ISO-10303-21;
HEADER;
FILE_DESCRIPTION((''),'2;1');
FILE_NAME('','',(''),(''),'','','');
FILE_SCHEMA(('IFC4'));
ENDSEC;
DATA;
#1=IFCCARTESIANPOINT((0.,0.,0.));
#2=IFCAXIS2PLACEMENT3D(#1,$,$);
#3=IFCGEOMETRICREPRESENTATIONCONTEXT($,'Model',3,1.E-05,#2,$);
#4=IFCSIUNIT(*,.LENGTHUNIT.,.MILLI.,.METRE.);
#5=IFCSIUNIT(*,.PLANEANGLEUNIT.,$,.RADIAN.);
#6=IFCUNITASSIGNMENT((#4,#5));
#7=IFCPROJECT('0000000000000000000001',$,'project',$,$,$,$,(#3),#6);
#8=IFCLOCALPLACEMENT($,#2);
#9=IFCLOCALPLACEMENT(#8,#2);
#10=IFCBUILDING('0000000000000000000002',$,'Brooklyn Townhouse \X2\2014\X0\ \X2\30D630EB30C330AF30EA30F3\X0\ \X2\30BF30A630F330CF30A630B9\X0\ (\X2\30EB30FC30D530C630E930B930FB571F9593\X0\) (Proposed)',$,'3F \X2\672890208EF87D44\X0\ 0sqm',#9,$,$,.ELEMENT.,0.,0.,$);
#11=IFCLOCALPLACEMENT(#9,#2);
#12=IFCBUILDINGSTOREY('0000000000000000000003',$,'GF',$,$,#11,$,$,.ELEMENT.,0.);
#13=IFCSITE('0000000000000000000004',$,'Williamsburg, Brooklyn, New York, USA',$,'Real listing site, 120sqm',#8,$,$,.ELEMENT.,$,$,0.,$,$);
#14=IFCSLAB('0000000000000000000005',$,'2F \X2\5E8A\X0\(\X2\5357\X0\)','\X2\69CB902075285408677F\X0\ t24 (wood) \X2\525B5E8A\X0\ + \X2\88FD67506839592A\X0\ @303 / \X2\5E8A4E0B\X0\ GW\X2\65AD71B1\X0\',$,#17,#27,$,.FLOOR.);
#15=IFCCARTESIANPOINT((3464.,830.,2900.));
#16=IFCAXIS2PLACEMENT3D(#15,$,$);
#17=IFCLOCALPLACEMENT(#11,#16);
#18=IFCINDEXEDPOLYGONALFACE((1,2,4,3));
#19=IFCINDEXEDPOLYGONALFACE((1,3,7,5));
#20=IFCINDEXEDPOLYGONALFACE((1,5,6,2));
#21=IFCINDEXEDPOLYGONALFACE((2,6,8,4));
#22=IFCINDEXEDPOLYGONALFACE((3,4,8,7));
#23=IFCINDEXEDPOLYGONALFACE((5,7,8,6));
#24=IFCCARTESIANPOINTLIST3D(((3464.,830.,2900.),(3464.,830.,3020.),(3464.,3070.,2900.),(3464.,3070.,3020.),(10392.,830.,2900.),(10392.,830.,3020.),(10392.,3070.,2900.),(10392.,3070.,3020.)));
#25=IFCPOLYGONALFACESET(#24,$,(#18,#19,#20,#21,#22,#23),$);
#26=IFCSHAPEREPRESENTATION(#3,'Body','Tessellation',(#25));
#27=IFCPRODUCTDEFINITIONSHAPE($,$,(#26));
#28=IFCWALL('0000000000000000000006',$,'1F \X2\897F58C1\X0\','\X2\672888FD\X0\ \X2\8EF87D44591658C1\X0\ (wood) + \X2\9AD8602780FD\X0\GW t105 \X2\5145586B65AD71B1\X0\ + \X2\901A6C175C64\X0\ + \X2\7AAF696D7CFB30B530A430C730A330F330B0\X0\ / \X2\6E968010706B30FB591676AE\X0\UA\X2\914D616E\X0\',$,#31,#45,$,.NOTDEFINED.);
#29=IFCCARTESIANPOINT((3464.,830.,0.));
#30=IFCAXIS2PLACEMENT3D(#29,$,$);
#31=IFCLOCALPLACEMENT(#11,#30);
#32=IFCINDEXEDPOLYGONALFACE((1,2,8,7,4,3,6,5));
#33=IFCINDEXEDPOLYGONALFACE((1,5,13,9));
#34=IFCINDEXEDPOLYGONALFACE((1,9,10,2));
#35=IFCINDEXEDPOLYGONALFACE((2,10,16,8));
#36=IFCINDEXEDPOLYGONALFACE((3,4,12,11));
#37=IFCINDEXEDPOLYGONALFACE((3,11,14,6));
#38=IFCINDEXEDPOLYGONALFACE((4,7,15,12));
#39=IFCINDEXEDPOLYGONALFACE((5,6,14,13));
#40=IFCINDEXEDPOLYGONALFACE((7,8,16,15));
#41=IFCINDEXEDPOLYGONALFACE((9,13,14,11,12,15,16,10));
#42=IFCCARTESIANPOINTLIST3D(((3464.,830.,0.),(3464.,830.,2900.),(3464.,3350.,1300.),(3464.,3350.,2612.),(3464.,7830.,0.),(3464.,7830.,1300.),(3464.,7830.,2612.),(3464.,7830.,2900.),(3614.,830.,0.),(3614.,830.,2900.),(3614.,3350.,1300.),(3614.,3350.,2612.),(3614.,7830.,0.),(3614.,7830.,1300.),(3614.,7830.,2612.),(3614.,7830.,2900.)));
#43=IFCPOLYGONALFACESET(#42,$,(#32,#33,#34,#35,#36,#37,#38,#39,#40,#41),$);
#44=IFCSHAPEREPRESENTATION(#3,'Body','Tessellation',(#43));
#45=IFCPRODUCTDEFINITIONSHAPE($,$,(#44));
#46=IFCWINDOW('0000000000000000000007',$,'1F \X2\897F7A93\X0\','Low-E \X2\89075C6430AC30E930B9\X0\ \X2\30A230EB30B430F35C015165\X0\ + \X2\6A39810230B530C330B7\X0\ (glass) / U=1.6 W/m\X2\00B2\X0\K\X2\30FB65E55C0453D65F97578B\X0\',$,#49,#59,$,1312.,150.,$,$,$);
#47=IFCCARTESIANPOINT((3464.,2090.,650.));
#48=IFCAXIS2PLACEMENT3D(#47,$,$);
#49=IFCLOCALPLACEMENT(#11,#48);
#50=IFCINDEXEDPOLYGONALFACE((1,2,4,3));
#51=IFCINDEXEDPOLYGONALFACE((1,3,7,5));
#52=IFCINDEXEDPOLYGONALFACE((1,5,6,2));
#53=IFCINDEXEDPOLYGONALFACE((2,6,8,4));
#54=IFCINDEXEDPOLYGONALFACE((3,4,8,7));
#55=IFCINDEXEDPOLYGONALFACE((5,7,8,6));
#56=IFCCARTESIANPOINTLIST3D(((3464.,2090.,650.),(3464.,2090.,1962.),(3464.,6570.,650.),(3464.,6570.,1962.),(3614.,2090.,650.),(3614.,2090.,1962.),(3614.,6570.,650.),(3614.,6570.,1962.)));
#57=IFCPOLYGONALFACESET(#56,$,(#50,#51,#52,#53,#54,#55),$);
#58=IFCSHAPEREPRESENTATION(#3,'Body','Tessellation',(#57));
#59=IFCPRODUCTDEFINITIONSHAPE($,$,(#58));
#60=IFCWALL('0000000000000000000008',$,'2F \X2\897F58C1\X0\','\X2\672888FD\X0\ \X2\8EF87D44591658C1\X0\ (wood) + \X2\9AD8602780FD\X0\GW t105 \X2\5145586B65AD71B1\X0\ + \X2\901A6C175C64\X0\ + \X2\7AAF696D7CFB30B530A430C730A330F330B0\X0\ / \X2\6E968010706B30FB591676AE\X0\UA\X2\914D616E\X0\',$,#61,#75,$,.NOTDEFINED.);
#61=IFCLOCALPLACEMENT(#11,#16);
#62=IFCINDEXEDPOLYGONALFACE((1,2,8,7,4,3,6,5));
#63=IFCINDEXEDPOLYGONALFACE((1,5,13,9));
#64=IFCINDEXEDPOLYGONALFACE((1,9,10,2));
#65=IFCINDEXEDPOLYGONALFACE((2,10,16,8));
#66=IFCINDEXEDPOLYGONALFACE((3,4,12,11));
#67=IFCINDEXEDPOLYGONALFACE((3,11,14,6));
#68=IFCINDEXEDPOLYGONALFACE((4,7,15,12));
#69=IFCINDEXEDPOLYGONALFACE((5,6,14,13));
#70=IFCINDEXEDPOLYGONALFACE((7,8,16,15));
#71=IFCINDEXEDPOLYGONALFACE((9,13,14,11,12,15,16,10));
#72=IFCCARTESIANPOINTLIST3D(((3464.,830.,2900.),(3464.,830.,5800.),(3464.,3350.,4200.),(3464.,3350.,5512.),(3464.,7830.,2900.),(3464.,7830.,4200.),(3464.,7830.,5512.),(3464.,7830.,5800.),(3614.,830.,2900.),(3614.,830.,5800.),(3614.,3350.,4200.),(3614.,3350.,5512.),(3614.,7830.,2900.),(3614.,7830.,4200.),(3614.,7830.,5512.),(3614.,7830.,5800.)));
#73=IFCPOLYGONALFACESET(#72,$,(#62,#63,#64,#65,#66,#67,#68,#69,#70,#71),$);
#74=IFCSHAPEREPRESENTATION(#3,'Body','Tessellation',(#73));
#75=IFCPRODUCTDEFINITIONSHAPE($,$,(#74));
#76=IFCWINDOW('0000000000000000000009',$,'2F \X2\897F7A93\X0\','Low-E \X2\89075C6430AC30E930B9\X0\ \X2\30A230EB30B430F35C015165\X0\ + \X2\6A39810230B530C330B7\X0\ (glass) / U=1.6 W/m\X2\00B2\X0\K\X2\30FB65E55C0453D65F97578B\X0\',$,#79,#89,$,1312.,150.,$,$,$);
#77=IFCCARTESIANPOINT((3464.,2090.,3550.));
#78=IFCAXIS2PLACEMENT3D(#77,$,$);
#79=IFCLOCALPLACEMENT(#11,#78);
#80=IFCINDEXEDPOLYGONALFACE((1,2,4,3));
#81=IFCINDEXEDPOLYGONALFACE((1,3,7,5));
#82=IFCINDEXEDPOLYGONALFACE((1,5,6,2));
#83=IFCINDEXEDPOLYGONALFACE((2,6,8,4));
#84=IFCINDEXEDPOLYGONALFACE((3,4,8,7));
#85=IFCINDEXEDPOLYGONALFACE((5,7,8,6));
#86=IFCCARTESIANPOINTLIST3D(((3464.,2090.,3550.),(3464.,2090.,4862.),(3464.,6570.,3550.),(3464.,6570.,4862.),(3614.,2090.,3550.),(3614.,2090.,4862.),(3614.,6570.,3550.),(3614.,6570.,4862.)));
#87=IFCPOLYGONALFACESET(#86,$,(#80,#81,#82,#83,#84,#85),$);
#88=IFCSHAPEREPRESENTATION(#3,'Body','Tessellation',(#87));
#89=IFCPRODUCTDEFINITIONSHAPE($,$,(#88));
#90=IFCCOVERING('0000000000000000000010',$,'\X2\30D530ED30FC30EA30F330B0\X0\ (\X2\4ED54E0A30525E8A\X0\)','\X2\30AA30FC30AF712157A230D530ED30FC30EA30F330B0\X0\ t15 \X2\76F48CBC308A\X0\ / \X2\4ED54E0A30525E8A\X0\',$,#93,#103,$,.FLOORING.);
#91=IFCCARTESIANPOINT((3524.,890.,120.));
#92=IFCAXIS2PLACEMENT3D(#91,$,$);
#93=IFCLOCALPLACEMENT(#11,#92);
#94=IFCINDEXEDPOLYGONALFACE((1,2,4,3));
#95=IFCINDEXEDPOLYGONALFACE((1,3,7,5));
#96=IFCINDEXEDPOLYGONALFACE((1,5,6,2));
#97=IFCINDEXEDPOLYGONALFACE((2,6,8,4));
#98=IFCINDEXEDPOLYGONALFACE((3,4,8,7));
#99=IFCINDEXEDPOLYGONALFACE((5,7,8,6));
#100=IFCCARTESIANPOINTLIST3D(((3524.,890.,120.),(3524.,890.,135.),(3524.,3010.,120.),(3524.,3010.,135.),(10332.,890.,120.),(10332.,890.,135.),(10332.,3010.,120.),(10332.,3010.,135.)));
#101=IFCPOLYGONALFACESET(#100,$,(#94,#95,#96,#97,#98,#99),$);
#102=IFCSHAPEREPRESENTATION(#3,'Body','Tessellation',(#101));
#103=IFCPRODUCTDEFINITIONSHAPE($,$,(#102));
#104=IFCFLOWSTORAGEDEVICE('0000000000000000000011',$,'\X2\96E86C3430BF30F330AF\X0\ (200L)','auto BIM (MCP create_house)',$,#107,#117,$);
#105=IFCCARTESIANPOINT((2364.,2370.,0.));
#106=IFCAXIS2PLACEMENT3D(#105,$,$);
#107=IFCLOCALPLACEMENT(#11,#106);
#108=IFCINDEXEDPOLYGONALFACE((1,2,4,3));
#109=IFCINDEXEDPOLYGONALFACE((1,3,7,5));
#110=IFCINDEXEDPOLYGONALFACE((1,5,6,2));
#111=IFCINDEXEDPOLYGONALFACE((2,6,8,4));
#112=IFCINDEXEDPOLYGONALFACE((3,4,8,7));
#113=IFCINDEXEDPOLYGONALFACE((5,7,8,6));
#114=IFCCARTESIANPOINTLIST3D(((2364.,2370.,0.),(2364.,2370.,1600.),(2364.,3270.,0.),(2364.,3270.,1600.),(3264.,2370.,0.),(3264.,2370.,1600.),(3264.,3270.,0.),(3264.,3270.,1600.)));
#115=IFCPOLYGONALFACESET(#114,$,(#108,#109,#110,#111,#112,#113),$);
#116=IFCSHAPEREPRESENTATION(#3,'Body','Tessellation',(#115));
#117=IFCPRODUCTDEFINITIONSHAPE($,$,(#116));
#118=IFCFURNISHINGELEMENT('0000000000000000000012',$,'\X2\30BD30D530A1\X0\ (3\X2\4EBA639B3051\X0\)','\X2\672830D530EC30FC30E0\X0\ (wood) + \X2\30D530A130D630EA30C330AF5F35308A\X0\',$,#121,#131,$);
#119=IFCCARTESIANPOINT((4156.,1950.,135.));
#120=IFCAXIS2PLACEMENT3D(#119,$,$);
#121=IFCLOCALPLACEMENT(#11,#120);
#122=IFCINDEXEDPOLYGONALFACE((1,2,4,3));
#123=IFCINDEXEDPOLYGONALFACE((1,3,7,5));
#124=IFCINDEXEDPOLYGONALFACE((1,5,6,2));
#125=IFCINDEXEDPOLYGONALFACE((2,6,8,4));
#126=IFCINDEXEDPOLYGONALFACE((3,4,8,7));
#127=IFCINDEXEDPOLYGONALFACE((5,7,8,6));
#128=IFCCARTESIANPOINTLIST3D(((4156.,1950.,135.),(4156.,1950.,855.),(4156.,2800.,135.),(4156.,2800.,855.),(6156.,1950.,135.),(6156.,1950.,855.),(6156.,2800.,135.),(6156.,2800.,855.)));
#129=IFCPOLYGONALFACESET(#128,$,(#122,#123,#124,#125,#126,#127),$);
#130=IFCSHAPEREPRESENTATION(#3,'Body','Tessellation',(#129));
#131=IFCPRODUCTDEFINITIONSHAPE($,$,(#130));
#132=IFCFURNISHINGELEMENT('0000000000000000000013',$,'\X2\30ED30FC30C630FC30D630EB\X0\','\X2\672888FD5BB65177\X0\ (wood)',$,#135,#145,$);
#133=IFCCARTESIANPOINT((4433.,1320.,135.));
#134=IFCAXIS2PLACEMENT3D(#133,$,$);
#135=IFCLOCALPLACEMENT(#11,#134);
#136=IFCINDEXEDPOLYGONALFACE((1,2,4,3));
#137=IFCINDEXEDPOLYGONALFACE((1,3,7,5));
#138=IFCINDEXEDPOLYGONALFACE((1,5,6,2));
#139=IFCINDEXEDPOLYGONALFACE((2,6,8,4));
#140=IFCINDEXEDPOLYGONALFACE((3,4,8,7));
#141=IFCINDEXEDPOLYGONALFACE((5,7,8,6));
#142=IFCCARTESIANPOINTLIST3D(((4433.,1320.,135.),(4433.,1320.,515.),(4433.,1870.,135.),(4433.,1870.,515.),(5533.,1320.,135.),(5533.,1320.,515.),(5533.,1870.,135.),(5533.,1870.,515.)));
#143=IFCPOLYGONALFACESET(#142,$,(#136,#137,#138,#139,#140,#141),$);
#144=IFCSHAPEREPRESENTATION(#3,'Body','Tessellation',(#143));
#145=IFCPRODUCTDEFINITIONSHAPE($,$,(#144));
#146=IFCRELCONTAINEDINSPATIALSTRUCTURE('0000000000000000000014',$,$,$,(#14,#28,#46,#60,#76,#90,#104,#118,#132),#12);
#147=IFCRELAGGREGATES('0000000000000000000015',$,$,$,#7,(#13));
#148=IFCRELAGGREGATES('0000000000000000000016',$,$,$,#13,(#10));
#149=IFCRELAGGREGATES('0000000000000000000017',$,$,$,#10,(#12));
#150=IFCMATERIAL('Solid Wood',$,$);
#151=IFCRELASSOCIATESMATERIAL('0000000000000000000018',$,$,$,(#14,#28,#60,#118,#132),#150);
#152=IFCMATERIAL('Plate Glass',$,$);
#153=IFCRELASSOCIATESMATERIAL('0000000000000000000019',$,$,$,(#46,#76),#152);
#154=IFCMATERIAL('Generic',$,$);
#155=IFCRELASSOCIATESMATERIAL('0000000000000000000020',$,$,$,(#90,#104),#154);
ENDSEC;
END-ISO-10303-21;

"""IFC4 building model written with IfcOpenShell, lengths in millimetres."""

from ifc_helpers import new_model, si_unit, frame, frame_2d, origin, place, context, project, spatial, rectangle, extrude, material, element, fill, save


model = new_model("IFC4")

# Units and contexts
model_context = context("Model", 3, precision=1e-05, world=origin())
ifc_project = project(units=[si_unit("LENGTHUNIT", "METRE", prefix="MILLI"), si_unit("PLANEANGLEUNIT", "RADIAN")], contexts=[model_context])

# Site, building, storey
site_placement = place(None, origin())
site = spatial("IfcSite", under=ifc_project, at=site_placement, Name="Williamsburg, Brooklyn, New York, USA", ObjectType="Real listing site, 120sqm", CompositionType="ELEMENT", RefElevation=0.0)
building_placement = place(site_placement, origin())
building = spatial("IfcBuilding", under=site, at=building_placement, Name="Brooklyn Townhouse — ブルックリン タウンハウス (ルーフテラス・土間) (Proposed)", ObjectType="3F 木造軸組 0sqm", CompositionType="ELEMENT", ElevationOfRefHeight=0.0, ElevationOfTerrain=0.0)
storey_placement = place(building_placement, origin())
storey = spatial("IfcBuildingStorey", under=building, at=storey_placement, Name="GF", CompositionType="ELEMENT", Elevation=0.0)

# Slab
ifc_material_1 = material(Name="Solid Wood")
slab_1_placement = place(storey_placement, frame((3464.0, 830.0, 2900.0)))
element("IfcSlab", 1, at=slab_1_placement, inside=storey, material=ifc_material_1, Name="2F 床(南)", Description="構造用合板 t24 (wood) 剛床 + 製材根太 @303 / 床下 GW断熱", PredefinedType="FLOOR", context=model_context, shape_type="SweptSolid", body=[
    extrude(rectangle(XDim=6928.0, YDim=2240.0, at=frame_2d((3464.0, 1120.0))), frame((3464.0, 830.0, 2900.0)), (0.0, 0.0, 1.0), 120.0),
])

# Shared definitions
ifc_material_2 = material(Name="Plate Glass")

# Walls, openings, windows
wall_1_placement = place(storey_placement, frame((3464.0, 830.0, 0.0)))
wall_1 = element("IfcWall", 2, at=wall_1_placement, inside=storey, material=ifc_material_1, Name="1F 西壁", Description="木製 軸組外壁 (wood) + 高性能GW t105 充填断熱 + 通気層 + 窯業系サイディング / 準耐火・外皮UA配慮", PredefinedType="NOTDEFINED", context=model_context, shape_type="SweptSolid", body=[
    extrude(rectangle(XDim=150.0, YDim=7000.0, at=frame_2d((75.0, 3500.0))), frame((3464.0, 830.0, 0.0)), (0.0, 0.0, 1.0), 2900.0),
])
opening_1_placement = place(storey_placement, frame((3464.0, 2090.0, 650.0)))
opening_1 = element("IfcOpeningElement", 3, at=opening_1_placement, cuts=wall_1, PredefinedType="NOTDEFINED", context=model_context, shape_type="SweptSolid", body=[
    extrude(rectangle(XDim=150.0, YDim=4480.0, at=frame_2d((75.0, 2240.0))), frame((3464.0, 2090.0, 650.0)), (0.0, 0.0, 1.0), 1312.0),
])
window_1_placement = place(storey_placement, frame((3464.0, 2090.0, 650.0)))
window_1 = element("IfcWindow", 4, at=window_1_placement, inside=storey, material=ifc_material_2, Name="1F 西窓", Description="Low-E 複層ガラス アルゴン封入 + 樹脂サッシ (glass) / U=1.6 W/m²K・日射取得型", OverallHeight=1312.0, OverallWidth=150.0, context=model_context, shape_type="SweptSolid", body=[
    extrude(rectangle(XDim=150.0, YDim=4480.0, at=frame_2d((75.0, 2240.0))), frame((3464.0, 2090.0, 650.0)), (0.0, 0.0, 1.0), 1312.0),
])
fill(opening_1, window_1)
wall_2_placement = place(storey_placement, frame((3464.0, 830.0, 2900.0)))
wall_2 = element("IfcWall", 5, at=wall_2_placement, inside=storey, material=ifc_material_1, Name="2F 西壁", Description="木製 軸組外壁 (wood) + 高性能GW t105 充填断熱 + 通気層 + 窯業系サイディング / 準耐火・外皮UA配慮", PredefinedType="NOTDEFINED", context=model_context, shape_type="SweptSolid", body=[
    extrude(rectangle(XDim=150.0, YDim=7000.0, at=frame_2d((75.0, 3500.0))), frame((3464.0, 830.0, 2900.0)), (0.0, 0.0, 1.0), 2900.0),
])
opening_2_placement = place(storey_placement, frame((3464.0, 2090.0, 3550.0)))
opening_2 = element("IfcOpeningElement", 6, at=opening_2_placement, cuts=wall_2, PredefinedType="NOTDEFINED", context=model_context, shape_type="SweptSolid", body=[
    extrude(rectangle(XDim=150.0, YDim=4480.0, at=frame_2d((75.0, 2240.0))), frame((3464.0, 2090.0, 3550.0)), (0.0, 0.0, 1.0), 1312.0),
])
window_2_placement = place(storey_placement, frame((3464.0, 2090.0, 3550.0)))
window_2 = element("IfcWindow", 7, at=window_2_placement, inside=storey, material=ifc_material_2, Name="2F 西窓", Description="Low-E 複層ガラス アルゴン封入 + 樹脂サッシ (glass) / U=1.6 W/m²K・日射取得型", OverallHeight=1312.0, OverallWidth=150.0, context=model_context, shape_type="SweptSolid", body=[
    extrude(rectangle(XDim=150.0, YDim=4480.0, at=frame_2d((75.0, 2240.0))), frame((3464.0, 2090.0, 3550.0)), (0.0, 0.0, 1.0), 1312.0),
])
fill(opening_2, window_2)

# Covering
ifc_material_3 = material(Name="Generic")
covering_placement = place(storey_placement, frame((3524.0, 890.0, 120.0)))
element("IfcCovering", 8, at=covering_placement, inside=storey, material=ifc_material_3, Name="フローリング (仕上げ床)", Description="オーク無垢フローリング t15 直貼り / 仕上げ床", PredefinedType="FLOORING", context=model_context, shape_type="SweptSolid", body=[
    extrude(rectangle(XDim=6808.0, YDim=2120.0, at=frame_2d((3404.0, 1060.0))), frame((3524.0, 890.0, 120.0)), (0.0, 0.0, 1.0), 15.0),
])

# Flow storage device
flow_storage_device_placement = place(storey_placement, frame((2364.0, 2370.0, 0.0)))
element("IfcFlowStorageDevice", 9, at=flow_storage_device_placement, inside=storey, material=ifc_material_3, Name="雨水タンク (200L)", Description="auto BIM (MCP create_house)", context=model_context, shape_type="SweptSolid", body=[
    extrude(rectangle(XDim=900.0, YDim=900.0, at=frame_2d((450.0, 450.0))), frame((2364.0, 2370.0, 0.0)), (0.0, 0.0, 1.0), 1600.0),
])

# Furnishing elements
furnishing_1_placement = place(storey_placement, frame((4156.0, 1950.0, 135.0)))
element("IfcFurnishingElement", 10, at=furnishing_1_placement, inside=storey, material=ifc_material_1, Name="ソファ (3人掛け)", Description="木フレーム (wood) + ファブリック張り", context=model_context, shape_type="SweptSolid", body=[
    extrude(rectangle(XDim=2000.0, YDim=850.0, at=frame_2d((1000.0, 425.0))), frame((4156.0, 1950.0, 135.0)), (0.0, 0.0, 1.0), 720.0),
])
furnishing_2_placement = place(storey_placement, frame((4433.0, 1320.0, 135.0)))
element("IfcFurnishingElement", 11, at=furnishing_2_placement, inside=storey, material=ifc_material_1, Name="ローテーブル", Description="木製家具 (wood)", context=model_context, shape_type="SweptSolid", body=[
    extrude(rectangle(XDim=1100.0, YDim=550.0, at=frame_2d((550.0, 275.0))), frame((4433.0, 1320.0, 135.0)), (0.0, 0.0, 1.0), 380.0),
])

save(model, "model.ifc")
